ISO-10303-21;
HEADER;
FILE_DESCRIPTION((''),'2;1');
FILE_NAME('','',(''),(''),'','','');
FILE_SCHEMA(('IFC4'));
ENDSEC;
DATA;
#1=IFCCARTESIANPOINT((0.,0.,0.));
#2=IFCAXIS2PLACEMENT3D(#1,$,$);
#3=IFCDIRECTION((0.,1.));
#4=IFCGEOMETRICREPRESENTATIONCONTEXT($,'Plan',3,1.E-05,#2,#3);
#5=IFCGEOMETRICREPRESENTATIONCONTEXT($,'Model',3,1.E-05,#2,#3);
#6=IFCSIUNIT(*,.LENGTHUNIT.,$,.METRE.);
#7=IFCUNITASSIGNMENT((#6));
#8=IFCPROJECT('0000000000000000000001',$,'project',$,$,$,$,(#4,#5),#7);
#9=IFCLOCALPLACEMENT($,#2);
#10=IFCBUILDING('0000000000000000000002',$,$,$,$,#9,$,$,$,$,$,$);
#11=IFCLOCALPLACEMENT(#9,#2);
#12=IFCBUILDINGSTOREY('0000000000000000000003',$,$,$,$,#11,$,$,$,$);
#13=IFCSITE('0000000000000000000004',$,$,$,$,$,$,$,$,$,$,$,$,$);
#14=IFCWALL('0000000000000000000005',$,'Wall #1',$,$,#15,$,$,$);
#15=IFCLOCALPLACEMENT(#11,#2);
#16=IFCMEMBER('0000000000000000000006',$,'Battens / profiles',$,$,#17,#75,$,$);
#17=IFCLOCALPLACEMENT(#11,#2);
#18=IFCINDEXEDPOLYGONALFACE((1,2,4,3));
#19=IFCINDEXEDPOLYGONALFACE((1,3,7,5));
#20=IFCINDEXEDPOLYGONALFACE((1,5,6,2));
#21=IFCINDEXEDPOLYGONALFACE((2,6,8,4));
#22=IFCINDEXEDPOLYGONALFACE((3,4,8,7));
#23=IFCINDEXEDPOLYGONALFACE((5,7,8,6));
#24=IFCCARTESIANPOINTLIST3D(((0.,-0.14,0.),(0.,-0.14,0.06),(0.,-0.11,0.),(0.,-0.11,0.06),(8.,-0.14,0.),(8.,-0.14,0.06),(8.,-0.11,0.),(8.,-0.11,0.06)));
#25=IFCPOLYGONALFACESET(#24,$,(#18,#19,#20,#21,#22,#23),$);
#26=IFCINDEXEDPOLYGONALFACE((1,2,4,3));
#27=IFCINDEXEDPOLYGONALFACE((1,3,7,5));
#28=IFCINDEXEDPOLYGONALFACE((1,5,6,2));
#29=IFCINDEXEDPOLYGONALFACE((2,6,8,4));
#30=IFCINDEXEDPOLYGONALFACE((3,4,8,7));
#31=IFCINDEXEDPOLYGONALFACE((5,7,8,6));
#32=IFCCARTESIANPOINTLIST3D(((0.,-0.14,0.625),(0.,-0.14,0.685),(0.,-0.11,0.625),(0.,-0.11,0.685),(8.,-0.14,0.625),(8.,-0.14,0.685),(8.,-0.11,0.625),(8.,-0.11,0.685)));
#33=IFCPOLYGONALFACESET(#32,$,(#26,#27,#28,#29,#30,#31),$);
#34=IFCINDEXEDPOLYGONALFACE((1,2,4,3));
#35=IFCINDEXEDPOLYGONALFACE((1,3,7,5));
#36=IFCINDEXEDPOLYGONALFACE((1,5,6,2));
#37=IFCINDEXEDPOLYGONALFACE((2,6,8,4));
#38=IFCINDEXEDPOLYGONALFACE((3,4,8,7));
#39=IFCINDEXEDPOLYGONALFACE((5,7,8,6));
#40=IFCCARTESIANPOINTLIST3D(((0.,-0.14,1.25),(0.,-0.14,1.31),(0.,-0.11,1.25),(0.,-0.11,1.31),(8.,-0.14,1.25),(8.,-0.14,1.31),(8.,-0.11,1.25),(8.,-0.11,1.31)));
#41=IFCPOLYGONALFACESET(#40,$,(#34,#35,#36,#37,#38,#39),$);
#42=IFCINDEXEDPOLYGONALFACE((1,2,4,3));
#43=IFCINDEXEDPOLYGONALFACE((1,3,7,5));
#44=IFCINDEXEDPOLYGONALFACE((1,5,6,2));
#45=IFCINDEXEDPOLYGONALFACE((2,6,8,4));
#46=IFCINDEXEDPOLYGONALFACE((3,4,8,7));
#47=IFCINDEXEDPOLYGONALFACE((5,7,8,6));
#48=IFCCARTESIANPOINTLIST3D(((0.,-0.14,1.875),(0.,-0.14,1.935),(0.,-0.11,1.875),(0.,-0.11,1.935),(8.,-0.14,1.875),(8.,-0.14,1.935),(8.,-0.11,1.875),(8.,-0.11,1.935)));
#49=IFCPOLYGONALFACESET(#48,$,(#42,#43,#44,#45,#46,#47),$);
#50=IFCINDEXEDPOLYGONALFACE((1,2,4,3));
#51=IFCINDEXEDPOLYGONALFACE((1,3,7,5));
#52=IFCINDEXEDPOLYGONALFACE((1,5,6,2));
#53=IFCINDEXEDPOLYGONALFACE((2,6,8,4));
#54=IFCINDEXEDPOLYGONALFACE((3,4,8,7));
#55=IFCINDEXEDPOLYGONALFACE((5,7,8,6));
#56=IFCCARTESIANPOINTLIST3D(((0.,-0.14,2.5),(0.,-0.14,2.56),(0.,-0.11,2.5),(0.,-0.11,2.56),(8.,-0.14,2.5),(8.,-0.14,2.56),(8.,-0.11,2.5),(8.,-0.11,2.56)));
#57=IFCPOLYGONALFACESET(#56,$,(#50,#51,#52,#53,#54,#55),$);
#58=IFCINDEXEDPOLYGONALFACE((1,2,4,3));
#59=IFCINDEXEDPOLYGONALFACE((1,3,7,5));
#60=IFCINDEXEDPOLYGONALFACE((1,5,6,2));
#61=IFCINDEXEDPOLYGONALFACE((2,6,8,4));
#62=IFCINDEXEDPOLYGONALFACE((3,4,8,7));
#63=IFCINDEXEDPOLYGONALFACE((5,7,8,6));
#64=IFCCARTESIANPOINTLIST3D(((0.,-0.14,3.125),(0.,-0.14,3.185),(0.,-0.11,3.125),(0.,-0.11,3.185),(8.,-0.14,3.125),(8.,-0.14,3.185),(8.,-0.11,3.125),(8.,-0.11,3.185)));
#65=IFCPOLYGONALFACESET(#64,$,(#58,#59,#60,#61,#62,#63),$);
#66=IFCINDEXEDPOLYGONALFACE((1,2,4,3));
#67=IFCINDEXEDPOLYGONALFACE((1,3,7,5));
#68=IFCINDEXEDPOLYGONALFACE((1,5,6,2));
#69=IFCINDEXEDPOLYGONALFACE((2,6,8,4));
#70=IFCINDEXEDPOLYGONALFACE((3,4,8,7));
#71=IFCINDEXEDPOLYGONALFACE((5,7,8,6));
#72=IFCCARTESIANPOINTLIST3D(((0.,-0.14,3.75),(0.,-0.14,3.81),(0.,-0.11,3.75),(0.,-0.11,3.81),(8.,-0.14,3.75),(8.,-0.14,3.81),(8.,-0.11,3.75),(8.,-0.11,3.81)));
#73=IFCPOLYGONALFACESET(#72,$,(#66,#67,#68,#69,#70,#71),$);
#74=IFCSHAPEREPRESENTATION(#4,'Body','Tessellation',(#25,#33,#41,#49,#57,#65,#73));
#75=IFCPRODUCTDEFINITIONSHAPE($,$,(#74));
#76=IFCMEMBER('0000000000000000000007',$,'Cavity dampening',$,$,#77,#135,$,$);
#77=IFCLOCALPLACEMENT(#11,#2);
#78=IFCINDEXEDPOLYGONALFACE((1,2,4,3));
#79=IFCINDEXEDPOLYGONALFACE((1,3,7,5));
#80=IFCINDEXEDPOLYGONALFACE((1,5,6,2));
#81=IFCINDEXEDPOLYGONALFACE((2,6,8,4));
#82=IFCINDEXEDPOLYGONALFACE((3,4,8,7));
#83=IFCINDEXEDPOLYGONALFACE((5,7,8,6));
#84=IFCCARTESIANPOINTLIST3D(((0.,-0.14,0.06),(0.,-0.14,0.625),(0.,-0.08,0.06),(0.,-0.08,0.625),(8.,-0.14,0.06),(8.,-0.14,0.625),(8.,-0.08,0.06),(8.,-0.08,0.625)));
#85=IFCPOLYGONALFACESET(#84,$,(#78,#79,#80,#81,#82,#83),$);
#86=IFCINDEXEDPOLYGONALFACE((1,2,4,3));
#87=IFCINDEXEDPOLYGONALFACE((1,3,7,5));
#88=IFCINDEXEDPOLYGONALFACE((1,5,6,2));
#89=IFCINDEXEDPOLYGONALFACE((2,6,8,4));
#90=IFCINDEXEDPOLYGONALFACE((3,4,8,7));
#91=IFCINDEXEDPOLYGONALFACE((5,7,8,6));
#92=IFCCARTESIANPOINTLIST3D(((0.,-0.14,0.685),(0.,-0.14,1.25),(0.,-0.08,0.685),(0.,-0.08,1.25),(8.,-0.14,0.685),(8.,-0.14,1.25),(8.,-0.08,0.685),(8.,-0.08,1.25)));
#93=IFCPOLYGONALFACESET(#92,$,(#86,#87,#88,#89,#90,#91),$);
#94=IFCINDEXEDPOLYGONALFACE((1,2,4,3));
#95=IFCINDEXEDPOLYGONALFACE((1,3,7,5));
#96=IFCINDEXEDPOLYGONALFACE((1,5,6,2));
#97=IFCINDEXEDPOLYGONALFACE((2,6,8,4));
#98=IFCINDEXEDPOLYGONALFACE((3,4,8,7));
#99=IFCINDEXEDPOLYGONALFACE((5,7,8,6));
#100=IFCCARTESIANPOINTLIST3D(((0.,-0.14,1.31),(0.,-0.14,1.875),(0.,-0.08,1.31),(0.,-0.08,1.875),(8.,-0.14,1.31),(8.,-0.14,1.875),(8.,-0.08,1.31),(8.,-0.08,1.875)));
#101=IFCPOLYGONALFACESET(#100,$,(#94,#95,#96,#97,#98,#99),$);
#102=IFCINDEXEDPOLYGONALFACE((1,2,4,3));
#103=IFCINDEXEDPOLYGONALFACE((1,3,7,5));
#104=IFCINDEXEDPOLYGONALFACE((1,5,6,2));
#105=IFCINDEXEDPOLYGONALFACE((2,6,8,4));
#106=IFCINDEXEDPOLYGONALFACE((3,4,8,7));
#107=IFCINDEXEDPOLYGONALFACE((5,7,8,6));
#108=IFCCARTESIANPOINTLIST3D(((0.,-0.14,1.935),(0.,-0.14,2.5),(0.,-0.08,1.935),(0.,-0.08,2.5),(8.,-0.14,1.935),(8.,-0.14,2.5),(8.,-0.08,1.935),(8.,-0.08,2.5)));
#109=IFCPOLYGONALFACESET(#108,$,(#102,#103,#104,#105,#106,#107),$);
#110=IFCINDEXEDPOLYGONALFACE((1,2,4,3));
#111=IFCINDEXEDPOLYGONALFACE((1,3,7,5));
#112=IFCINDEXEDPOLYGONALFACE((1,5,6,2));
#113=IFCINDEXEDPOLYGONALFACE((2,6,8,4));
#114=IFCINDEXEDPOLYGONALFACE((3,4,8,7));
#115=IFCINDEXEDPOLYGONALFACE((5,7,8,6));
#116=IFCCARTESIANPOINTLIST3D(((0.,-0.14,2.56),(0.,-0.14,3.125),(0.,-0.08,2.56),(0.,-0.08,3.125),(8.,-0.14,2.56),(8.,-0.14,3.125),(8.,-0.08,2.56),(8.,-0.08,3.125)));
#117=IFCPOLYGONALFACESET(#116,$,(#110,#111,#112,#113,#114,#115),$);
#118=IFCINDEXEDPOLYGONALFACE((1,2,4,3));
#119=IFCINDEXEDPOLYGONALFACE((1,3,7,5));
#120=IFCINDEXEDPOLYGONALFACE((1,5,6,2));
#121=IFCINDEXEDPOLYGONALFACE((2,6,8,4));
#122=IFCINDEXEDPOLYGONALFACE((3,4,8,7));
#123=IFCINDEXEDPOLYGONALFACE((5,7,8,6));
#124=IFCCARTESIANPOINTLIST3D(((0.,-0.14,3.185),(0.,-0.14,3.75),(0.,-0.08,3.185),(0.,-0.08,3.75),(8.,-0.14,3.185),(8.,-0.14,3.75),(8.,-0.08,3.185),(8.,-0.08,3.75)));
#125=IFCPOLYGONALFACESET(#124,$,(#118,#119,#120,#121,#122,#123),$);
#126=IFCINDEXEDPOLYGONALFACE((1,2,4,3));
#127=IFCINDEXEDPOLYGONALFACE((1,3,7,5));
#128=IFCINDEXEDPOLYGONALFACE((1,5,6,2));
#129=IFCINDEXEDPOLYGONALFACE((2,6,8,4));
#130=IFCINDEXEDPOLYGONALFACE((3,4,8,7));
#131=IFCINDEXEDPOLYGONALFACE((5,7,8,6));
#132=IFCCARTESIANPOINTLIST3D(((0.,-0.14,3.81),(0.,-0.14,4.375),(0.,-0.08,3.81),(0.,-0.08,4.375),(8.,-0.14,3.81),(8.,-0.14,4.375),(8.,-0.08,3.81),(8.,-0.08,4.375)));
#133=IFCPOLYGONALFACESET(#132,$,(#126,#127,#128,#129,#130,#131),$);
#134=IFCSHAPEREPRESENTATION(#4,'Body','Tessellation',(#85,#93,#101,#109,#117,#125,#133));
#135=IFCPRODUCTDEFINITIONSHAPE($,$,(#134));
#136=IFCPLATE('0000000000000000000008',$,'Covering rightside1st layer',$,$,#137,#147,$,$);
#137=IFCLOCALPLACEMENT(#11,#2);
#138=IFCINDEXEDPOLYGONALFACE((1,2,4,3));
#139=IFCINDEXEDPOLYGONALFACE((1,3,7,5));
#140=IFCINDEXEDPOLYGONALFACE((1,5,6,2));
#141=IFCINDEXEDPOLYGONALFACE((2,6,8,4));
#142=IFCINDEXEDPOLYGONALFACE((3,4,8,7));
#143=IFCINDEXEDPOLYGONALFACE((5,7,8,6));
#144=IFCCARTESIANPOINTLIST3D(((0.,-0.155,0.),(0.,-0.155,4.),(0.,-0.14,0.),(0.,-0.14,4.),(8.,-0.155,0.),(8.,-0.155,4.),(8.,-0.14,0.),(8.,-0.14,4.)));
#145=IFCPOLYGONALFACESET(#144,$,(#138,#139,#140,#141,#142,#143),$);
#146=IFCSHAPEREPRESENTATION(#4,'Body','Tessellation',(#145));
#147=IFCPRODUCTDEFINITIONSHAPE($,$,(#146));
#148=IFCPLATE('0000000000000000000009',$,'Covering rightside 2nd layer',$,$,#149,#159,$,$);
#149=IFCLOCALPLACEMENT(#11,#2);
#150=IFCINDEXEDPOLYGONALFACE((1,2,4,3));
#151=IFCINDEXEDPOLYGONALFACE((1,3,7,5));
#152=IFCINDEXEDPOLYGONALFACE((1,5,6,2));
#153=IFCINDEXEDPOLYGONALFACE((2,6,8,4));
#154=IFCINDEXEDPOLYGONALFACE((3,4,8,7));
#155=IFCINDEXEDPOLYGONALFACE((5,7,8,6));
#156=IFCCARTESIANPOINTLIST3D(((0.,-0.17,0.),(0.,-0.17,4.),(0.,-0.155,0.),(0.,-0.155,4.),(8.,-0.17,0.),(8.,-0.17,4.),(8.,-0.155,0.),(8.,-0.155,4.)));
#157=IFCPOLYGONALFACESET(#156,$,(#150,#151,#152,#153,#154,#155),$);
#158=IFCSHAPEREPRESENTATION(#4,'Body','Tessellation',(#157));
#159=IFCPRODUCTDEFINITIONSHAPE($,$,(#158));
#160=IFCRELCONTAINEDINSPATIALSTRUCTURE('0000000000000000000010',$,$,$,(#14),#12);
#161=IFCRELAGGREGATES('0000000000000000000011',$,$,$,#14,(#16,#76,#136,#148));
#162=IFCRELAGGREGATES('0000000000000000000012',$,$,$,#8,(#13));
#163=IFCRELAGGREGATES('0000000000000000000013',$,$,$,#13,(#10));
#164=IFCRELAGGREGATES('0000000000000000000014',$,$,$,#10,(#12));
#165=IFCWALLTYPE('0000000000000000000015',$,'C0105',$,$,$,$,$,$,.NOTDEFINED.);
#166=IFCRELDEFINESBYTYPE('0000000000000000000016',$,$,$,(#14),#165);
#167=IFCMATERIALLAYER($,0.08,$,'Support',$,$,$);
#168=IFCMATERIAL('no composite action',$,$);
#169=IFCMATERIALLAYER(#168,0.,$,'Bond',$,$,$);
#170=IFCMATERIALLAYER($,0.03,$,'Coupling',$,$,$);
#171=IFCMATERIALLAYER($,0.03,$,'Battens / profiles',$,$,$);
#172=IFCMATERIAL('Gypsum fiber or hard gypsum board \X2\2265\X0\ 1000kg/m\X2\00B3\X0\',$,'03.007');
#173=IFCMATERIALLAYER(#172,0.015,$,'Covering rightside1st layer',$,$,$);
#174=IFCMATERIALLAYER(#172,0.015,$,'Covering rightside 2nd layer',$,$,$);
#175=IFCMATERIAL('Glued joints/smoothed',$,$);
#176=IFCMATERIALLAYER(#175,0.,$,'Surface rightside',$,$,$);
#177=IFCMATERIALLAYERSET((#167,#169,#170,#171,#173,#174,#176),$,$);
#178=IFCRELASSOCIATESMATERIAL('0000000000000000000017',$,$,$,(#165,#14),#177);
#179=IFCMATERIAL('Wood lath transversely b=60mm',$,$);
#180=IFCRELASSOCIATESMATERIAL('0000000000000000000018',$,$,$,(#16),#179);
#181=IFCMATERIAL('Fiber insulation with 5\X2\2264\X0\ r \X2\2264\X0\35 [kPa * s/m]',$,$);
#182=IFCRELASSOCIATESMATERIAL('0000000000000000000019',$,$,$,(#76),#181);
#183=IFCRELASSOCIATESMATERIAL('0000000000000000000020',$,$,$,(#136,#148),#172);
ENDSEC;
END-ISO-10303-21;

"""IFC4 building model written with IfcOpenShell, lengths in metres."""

from ifc_helpers import new_model, si_unit, direction, frame, frame_2d, origin, place, context, project, spatial, rectangle, extrude, material, layer, layer_set, type_object, element, aggregate, save


model = new_model("IFC4")

# Units and contexts
plan_context = context("Plan", 3, precision=1e-05, world=origin(), true_north=direction((0.0, 1.0)))
model_context = context("Model", 3, precision=1e-05, world=origin(), true_north=direction((0.0, 1.0)))
ifc_project = project(units=[si_unit("LENGTHUNIT", "METRE")], contexts=[plan_context, model_context])

# Site, building, storey
site = spatial("IfcSite", under=ifc_project)
building_placement = place(None, origin())
building = spatial("IfcBuilding", under=site, at=building_placement)
storey_placement = place(building_placement, origin())
storey = spatial("IfcBuildingStorey", under=building, at=storey_placement)

# Wall, members, plates
ifc_layer_1 = layer(None, 0.08, Name="Support")
ifc_material_1 = material(Name="no composite action")
ifc_layer_2 = layer(ifc_material_1, 0.0, Name="Bond")
ifc_layer_3 = layer(None, 0.03, Name="Coupling")
ifc_layer_4 = layer(None, 0.03, Name="Battens / profiles")
ifc_material_2 = material(Name="Gypsum fiber or hard gypsum board ≥ 1000kg/m³", Category="03.007")
ifc_layer_5 = layer(ifc_material_2, 0.015, Name="Covering rightside1st layer")
ifc_layer_6 = layer(ifc_material_2, 0.015, Name="Covering rightside 2nd layer")
ifc_material_3 = material(Name="Glued joints/smoothed")
ifc_layer_7 = layer(ifc_material_3, 0.0, Name="Surface rightside")
ifc_layer_set = layer_set([ifc_layer_1, ifc_layer_2, ifc_layer_3, ifc_layer_4, ifc_layer_5, ifc_layer_6, ifc_layer_7])
wall_type = type_object("IfcWallType", Name="C0105", PredefinedType="NOTDEFINED", material=ifc_layer_set)
wall_placement = place(None, frame((0.0, 0.0, 0.0), z_axis=(0.0, -1.0, 0.0), x_axis=(1.0, 0.0, 0.0)))
wall = element("IfcWall", 1, at=wall_placement, inside=storey, type_object=wall_type, material=ifc_layer_set, Name="Wall #1")
ifc_material_4 = material(Name="Wood lath transversely b=60mm")
member_1_placement = place(wall_placement, origin())
member_1 = element("IfcMember", 2, at=member_1_placement, material=ifc_material_4, Name="Battens / profiles", context=plan_context, shape_type="SweptSolid", body=[
    extrude(rectangle(XDim=0.06, YDim=0.03, at=frame_2d((0.03, 0.015), x_axis=(1.0, 0.0))), frame((0.0, 0.0, 0.11), z_axis=(1.0, 0.0, 0.0), x_axis=(0.0, 1.0, 0.0)), (0.0, 0.0, 1.0), 8.0),
    extrude(rectangle(XDim=0.06, YDim=0.03, at=frame_2d((0.03, 0.015), x_axis=(1.0, 0.0))), frame((0.0, 0.625, 0.11), z_axis=(1.0, 0.0, 0.0), x_axis=(0.0, 1.0, 0.0)), (0.0, 0.0, 1.0), 8.0),
    extrude(rectangle(XDim=0.06, YDim=0.03, at=frame_2d((0.03, 0.015), x_axis=(1.0, 0.0))), frame((0.0, 1.25, 0.11), z_axis=(1.0, 0.0, 0.0), x_axis=(0.0, 1.0, 0.0)), (0.0, 0.0, 1.0), 8.0),
    extrude(rectangle(XDim=0.06, YDim=0.03, at=frame_2d((0.03, 0.015), x_axis=(1.0, 0.0))), frame((0.0, 1.875, 0.11), z_axis=(1.0, 0.0, 0.0), x_axis=(0.0, 1.0, 0.0)), (0.0, 0.0, 1.0), 8.0),
    extrude(rectangle(XDim=0.06, YDim=0.03, at=frame_2d((0.03, 0.015), x_axis=(1.0, 0.0))), frame((0.0, 2.5, 0.11), z_axis=(1.0, 0.0, 0.0), x_axis=(0.0, 1.0, 0.0)), (0.0, 0.0, 1.0), 8.0),
    extrude(rectangle(XDim=0.06, YDim=0.03, at=frame_2d((0.03, 0.015), x_axis=(1.0, 0.0))), frame((0.0, 3.125, 0.11), z_axis=(1.0, 0.0, 0.0), x_axis=(0.0, 1.0, 0.0)), (0.0, 0.0, 1.0), 8.0),
    extrude(rectangle(XDim=0.06, YDim=0.03, at=frame_2d((0.03, 0.015), x_axis=(1.0, 0.0))), frame((0.0, 3.75, 0.11), z_axis=(1.0, 0.0, 0.0), x_axis=(0.0, 1.0, 0.0)), (0.0, 0.0, 1.0), 8.0),
])
ifc_material_5 = material(Name="Fiber insulation with 5≤ r ≤35 [kPa * s/m]")
member_2_placement = place(wall_placement, origin())
member_2 = element("IfcMember", 3, at=member_2_placement, material=ifc_material_5, Name="Cavity dampening", context=plan_context, shape_type="SweptSolid", body=[
    extrude(rectangle(XDim=0.565, YDim=0.06, at=frame_2d((0.2825, 0.03), x_axis=(1.0, 0.0))), frame((0.0, 0.06, 0.08), z_axis=(1.0, 0.0, 0.0), x_axis=(0.0, 1.0, 0.0)), (0.0, 0.0, 1.0), 8.0),
    extrude(rectangle(XDim=0.565, YDim=0.06, at=frame_2d((0.2825, 0.03), x_axis=(1.0, 0.0))), frame((0.0, 0.685, 0.08), z_axis=(1.0, 0.0, 0.0), x_axis=(0.0, 1.0, 0.0)), (0.0, 0.0, 1.0), 8.0),
    extrude(rectangle(XDim=0.565, YDim=0.06, at=frame_2d((0.2825, 0.03), x_axis=(1.0, 0.0))), frame((0.0, 1.31, 0.08), z_axis=(1.0, 0.0, 0.0), x_axis=(0.0, 1.0, 0.0)), (0.0, 0.0, 1.0), 8.0),
    extrude(rectangle(XDim=0.565, YDim=0.06, at=frame_2d((0.2825, 0.03), x_axis=(1.0, 0.0))), frame((0.0, 1.935, 0.08), z_axis=(1.0, 0.0, 0.0), x_axis=(0.0, 1.0, 0.0)), (0.0, 0.0, 1.0), 8.0),
    extrude(rectangle(XDim=0.565, YDim=0.06, at=frame_2d((0.2825, 0.03), x_axis=(1.0, 0.0))), frame((0.0, 2.56, 0.08), z_axis=(1.0, 0.0, 0.0), x_axis=(0.0, 1.0, 0.0)), (0.0, 0.0, 1.0), 8.0),
    extrude(rectangle(XDim=0.565, YDim=0.06, at=frame_2d((0.2825, 0.03), x_axis=(1.0, 0.0))), frame((0.0, 3.185, 0.08), z_axis=(1.0, 0.0, 0.0), x_axis=(0.0, 1.0, 0.0)), (0.0, 0.0, 1.0), 8.0),
    extrude(rectangle(XDim=0.565, YDim=0.06, at=frame_2d((0.2825, 0.03), x_axis=(1.0, 0.0))), frame((0.0, 3.81, 0.08), z_axis=(1.0, 0.0, 0.0), x_axis=(0.0, 1.0, 0.0)), (0.0, 0.0, 1.0), 8.0),
])
plate_1_placement = place(wall_placement, origin())
plate_1 = element("IfcPlate", 4, at=plate_1_placement, material=ifc_material_2, Name="Covering rightside1st layer", context=plan_context, shape_type="SweptSolid", body=[
    extrude(rectangle(XDim=8.0, YDim=4.0, at=frame_2d((4.0, 2.0), x_axis=(1.0, 0.0))), frame((0.0, 0.0, 0.14), z_axis=(0.0, 0.0, 1.0), x_axis=(1.0, 0.0, 0.0)), (0.0, 0.0, 1.0), 0.015),
])
plate_2_placement = place(wall_placement, origin())
plate_2 = element("IfcPlate", 5, at=plate_2_placement, material=ifc_material_2, Name="Covering rightside 2nd layer", context=plan_context, shape_type="SweptSolid", body=[
    extrude(rectangle(XDim=8.0, YDim=4.0, at=frame_2d((4.0, 2.0), x_axis=(1.0, 0.0))), frame((0.0, 0.0, 0.155), z_axis=(0.0, 0.0, 1.0), x_axis=(1.0, 0.0, 0.0)), (0.0, 0.0, 1.0), 0.015),
])
aggregate(wall, [member_1, member_2, plate_1, plate_2])

save(model, "model.ifc")
